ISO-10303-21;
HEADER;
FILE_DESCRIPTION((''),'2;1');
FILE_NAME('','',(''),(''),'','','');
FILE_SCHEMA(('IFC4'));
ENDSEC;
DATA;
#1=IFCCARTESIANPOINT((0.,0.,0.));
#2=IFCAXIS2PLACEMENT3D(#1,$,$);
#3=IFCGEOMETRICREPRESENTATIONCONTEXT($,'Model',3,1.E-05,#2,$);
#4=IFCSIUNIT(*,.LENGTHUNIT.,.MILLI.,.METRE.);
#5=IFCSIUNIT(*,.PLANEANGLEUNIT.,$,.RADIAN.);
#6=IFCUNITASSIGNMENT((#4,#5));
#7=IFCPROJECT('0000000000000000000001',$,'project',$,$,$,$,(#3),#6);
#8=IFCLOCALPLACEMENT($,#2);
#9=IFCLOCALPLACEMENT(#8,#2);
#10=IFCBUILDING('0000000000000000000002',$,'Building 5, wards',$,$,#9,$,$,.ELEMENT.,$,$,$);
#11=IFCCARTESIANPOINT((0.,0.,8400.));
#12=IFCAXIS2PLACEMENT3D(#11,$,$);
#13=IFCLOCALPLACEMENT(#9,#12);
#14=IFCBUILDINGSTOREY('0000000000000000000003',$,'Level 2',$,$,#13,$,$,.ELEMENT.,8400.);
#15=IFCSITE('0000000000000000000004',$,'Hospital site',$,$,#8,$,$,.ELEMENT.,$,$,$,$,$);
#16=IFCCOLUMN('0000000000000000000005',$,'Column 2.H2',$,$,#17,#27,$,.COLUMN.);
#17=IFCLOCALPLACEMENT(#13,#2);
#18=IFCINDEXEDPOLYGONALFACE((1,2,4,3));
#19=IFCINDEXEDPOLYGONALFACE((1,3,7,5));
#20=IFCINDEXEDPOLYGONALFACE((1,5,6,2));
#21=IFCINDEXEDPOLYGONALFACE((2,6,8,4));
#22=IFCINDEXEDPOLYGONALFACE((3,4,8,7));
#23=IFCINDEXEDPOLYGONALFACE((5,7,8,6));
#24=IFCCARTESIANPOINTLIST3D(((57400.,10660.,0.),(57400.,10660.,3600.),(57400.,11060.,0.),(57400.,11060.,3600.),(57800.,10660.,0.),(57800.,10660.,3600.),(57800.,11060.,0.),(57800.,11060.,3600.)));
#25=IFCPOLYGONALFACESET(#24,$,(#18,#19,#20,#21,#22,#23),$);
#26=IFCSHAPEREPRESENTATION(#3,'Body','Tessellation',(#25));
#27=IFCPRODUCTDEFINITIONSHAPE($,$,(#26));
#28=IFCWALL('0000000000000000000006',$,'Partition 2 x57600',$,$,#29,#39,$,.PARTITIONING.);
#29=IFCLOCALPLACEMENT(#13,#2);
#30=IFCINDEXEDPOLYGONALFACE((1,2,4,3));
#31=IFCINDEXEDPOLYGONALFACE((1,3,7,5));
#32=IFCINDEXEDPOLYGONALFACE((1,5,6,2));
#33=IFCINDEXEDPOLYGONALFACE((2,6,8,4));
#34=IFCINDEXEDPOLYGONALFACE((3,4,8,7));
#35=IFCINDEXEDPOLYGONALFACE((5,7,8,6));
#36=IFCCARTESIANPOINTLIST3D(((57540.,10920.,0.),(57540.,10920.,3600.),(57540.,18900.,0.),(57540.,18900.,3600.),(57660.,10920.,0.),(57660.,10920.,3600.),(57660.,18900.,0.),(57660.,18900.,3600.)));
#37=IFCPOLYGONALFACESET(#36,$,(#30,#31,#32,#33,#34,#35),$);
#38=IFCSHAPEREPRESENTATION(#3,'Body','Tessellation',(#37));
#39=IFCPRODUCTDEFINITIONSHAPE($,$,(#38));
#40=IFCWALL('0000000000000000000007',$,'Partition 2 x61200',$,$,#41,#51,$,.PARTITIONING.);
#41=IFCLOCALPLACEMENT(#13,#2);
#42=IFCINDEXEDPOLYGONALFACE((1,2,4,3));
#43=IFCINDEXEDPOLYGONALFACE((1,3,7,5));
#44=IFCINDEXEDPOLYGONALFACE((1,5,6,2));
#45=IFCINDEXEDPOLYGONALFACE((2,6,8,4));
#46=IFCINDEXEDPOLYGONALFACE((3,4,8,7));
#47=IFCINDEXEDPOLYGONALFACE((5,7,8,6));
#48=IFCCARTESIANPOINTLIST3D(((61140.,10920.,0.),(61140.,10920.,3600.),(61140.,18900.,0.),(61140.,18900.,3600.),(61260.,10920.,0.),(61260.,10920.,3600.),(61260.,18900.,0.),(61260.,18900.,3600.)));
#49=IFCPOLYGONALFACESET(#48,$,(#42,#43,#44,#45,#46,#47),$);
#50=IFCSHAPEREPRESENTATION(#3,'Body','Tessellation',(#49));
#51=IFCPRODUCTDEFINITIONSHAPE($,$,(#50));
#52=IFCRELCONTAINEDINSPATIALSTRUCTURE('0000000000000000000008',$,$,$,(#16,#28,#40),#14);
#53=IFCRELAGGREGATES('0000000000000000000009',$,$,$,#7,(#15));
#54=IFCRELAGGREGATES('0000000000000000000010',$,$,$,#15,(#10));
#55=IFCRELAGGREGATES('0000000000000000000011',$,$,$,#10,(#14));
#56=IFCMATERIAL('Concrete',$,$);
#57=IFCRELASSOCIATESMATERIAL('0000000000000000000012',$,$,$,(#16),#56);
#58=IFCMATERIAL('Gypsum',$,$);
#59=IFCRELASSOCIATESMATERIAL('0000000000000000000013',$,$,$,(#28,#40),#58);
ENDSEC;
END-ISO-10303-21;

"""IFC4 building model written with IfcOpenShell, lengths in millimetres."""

from ifc_helpers import new_model, si_unit, frame, frame_2d, origin, origin_2d, place, context, project, spatial, rectangle, extrude, material, element, save


model = new_model("IFC4")

# Units and contexts
model_context = context("Model", 3, precision=1e-05, world=origin())
ifc_project = project(units=[si_unit("LENGTHUNIT", "METRE", prefix="MILLI"), si_unit("PLANEANGLEUNIT", "RADIAN")], contexts=[model_context])

# Site, building, storey
site_placement = place(None, origin())
site = spatial("IfcSite", under=ifc_project, at=site_placement, Name="Hospital site", CompositionType="ELEMENT")
building_placement = place(site_placement, origin())
building = spatial("IfcBuilding", under=site, at=building_placement, Name="Building 5, wards", CompositionType="ELEMENT")
storey_placement = place(building_placement, frame((0.0, 0.0, 8400.0)))
storey = spatial("IfcBuildingStorey", under=building, at=storey_placement, Name="Level 2", CompositionType="ELEMENT", Elevation=8400.0)

# Column
ifc_material_1 = material(Name="Concrete")
column_placement = place(storey_placement, frame((57600.0, 10860.0, 0.0)))
element("IfcColumn", 1, at=column_placement, inside=storey, material=ifc_material_1, Name="Column 2.H2", PredefinedType="COLUMN", context=model_context, shape_type="SweptSolid", body=[
    extrude(rectangle(XDim=400.0, YDim=400.0, at=origin_2d()), origin(), (0.0, 0.0, 1.0), 3600.0),
])

# Walls
ifc_material_2 = material(Name="Gypsum")
for number, where, x_axis, name in (
    (2, (57660.0, 10920.0, 0.0), (0.0, 1.0, 0.0), "Partition 2 x57600"),
    (3, (61260.0, 10920.0, 0.0), (0.0, 1.0, 0.0), "Partition 2 x61200"),
):
    element("IfcWall", number, at=place(storey_placement, frame(where, x_axis=x_axis)), inside=storey, material=ifc_material_2, Name=name, PredefinedType="PARTITIONING", context=model_context, shape_type="SweptSolid", body=[
        extrude(rectangle(XDim=7980.0, YDim=120.0, at=frame_2d((3990.0, 60.0))), origin(), (0.0, 0.0, 1.0), 3600.0),
    ])

save(model, "model.ifc")
